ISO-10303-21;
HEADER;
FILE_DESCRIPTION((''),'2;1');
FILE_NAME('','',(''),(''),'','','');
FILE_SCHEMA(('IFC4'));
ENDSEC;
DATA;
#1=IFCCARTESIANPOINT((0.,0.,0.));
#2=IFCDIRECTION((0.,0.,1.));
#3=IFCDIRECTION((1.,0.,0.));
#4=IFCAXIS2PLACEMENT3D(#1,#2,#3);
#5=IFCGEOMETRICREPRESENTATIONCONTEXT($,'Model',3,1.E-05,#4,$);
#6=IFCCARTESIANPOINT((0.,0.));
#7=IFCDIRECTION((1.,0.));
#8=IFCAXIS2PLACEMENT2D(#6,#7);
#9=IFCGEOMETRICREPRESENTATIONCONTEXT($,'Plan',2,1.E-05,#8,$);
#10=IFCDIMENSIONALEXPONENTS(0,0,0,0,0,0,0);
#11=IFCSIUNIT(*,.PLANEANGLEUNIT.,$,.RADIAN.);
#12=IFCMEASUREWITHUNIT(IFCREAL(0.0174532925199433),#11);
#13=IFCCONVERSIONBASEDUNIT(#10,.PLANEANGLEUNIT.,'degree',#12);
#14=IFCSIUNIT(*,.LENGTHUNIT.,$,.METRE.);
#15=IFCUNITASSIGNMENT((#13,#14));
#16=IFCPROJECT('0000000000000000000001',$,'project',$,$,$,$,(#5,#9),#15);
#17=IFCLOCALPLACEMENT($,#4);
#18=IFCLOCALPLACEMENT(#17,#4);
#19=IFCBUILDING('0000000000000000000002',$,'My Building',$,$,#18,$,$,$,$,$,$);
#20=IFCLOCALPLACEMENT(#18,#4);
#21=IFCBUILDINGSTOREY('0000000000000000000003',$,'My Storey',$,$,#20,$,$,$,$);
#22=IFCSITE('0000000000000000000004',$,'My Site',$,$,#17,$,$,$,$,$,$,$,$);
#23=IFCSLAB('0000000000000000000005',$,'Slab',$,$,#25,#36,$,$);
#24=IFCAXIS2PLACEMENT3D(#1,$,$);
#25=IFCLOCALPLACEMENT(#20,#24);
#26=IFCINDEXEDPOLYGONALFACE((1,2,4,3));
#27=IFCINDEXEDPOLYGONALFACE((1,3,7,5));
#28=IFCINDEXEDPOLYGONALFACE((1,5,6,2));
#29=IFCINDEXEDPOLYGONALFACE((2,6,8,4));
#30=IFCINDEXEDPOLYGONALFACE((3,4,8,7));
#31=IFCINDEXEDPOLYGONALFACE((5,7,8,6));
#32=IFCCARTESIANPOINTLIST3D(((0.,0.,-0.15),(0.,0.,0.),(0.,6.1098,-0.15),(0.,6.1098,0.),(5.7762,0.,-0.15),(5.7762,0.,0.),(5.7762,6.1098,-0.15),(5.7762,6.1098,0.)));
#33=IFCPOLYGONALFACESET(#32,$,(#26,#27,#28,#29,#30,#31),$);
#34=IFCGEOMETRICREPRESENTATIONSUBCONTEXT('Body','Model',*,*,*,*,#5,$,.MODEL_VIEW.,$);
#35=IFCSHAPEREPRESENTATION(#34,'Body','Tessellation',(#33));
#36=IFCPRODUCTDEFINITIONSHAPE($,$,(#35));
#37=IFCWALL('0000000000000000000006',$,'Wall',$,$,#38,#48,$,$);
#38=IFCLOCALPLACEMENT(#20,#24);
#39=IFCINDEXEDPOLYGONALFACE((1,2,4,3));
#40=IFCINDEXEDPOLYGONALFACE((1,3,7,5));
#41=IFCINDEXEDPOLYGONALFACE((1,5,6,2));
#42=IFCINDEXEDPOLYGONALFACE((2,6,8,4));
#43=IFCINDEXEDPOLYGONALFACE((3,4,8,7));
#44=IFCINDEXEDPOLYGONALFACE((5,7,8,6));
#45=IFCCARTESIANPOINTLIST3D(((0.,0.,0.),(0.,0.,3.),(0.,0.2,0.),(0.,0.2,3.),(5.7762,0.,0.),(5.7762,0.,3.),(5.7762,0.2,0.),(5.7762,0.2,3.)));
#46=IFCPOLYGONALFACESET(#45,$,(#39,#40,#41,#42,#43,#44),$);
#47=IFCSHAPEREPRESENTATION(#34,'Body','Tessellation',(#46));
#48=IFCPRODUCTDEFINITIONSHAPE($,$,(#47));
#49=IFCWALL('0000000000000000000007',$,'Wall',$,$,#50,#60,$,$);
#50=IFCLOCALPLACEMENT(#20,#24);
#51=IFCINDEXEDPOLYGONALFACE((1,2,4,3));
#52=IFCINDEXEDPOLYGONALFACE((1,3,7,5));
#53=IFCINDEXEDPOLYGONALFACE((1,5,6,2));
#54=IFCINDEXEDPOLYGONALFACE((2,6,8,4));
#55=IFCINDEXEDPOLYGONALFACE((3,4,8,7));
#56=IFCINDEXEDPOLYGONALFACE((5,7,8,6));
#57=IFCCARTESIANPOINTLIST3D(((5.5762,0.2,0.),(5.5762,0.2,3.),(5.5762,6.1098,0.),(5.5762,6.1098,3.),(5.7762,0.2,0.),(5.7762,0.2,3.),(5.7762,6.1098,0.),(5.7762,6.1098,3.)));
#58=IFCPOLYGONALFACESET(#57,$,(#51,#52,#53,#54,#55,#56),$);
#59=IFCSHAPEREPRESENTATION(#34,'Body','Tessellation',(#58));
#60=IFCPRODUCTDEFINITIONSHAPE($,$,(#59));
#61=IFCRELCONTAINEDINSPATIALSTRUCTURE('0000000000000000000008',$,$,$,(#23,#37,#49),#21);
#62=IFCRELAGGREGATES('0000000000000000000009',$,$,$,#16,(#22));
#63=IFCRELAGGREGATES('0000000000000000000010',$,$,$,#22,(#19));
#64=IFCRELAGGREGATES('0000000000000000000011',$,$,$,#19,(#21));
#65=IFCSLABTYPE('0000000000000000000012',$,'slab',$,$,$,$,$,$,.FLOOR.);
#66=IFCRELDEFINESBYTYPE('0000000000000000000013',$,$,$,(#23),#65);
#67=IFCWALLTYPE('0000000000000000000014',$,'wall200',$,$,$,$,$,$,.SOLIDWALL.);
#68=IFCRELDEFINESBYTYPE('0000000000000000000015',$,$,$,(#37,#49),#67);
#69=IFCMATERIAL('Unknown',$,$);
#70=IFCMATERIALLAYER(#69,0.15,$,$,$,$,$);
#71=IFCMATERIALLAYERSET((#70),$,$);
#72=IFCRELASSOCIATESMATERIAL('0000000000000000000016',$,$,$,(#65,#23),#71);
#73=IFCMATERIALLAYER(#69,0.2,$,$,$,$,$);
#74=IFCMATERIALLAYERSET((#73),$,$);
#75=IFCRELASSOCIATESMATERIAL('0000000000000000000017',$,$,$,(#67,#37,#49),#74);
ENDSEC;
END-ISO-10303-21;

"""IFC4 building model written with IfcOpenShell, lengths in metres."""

from ifc_helpers import new_model, entity, si_unit, converted_unit, frame, origin_with_axes, origin_2d_with_axis, place, context, subcontext, project, spatial, line, indexed_curve, outline, extrude, material, layer, layer_set, layer_usage, type_object, element, save


model = new_model("IFC4")

# Units and contexts
model_context = context("Model", 3, precision=1e-05, world=origin_with_axes())
plan_context = context("Plan", 2, precision=1e-05, world=origin_2d_with_axis())
body_context = subcontext(model_context, "Body", "Model", "MODEL_VIEW")
ifc_project = project(units=[converted_unit("PLANEANGLEUNIT", "degree", entity("IfcReal", 0.0174532925199433), si_unit("PLANEANGLEUNIT", "RADIAN"), dimensions=[0, 0, 0, 0, 0, 0, 0]), si_unit("LENGTHUNIT", "METRE")], contexts=[model_context, plan_context])

# Site, building, storey
site_placement = place(None, origin_with_axes())
site = spatial("IfcSite", under=ifc_project, at=site_placement, Name="My Site")
building_placement = place(site_placement, origin_with_axes())
building = spatial("IfcBuilding", under=site, at=building_placement, Name="My Building")
storey_placement = place(building_placement, origin_with_axes())
storey = spatial("IfcBuildingStorey", under=building, at=storey_placement, Name="My Storey")

# Slab
ifc_material = material(Name="Unknown")
ifc_layer_1 = layer(ifc_material, 0.15)
ifc_layer_set_1 = layer_set([ifc_layer_1])
ifc_layer_usage_1 = layer_usage(ifc_layer_set_1, "AXIS3", "POSITIVE", 0.0)
slab_type = type_object("IfcSlabType", Name="slab", PredefinedType="FLOOR", material=ifc_layer_set_1)
slab_placement = place(storey_placement, frame((0.0, 0.0, -0.15), z_axis=(0.0, 0.0, 1.0), x_axis=(1.0, 0.0, 0.0)))
element("IfcSlab", 1, at=slab_placement, inside=storey, type_object=slab_type, material=ifc_layer_usage_1, Name="Slab", context=body_context, shape_type="SweptSolid", body=[
    extrude(outline(indexed_curve([(0.0, 0.0), (5.7762, 0.0), (5.7762, 6.1098), (0.0, 6.1098)], segments=[line(3, 2), line(2, 1), line(1, 4), line(4, 3)], self_intersect=False)), None, (0.0, 0.0, 1.0), 0.15),
])

# Walls
ifc_layer_2 = layer(ifc_material, 0.2)
ifc_layer_set_2 = layer_set([ifc_layer_2])
ifc_layer_usage_2 = layer_usage(ifc_layer_set_2, "AXIS2", "POSITIVE", 0.0)
wall_type = type_object("IfcWallType", Name="wall200", PredefinedType="SOLIDWALL", material=ifc_layer_set_2)
wall_1_placement = place(storey_placement, origin_with_axes())
element("IfcWall", 2, at=wall_1_placement, inside=storey, type_object=wall_type, material=ifc_layer_usage_2, Name="Wall", context=body_context, shape_type="SweptSolid", body=[
    extrude(outline(indexed_curve([(0.0, 0.0), (0.0, 0.2), (5.7762, 0.2), (5.7762, 0.0), (0.0, 0.0)], self_intersect=False)), origin_with_axes(), (0.0, 0.0, 1.0), 3.0),
])
ifc_layer_usage_3 = layer_usage(ifc_layer_set_2, "AXIS2", "POSITIVE", 0.0)
wall_2_placement = place(storey_placement, frame((5.7762, 0.2, 0.0), z_axis=(0.0, 0.0, 1.0), x_axis=(0.0, 1.0, 0.0)))
element("IfcWall", 3, at=wall_2_placement, inside=storey, type_object=wall_type, material=ifc_layer_usage_3, Name="Wall", context=body_context, shape_type="SweptSolid", body=[
    extrude(outline(indexed_curve([(0.0, 0.0), (0.0, 0.2), (5.9098, 0.2), (5.9098, 0.0), (0.0, 0.0)], self_intersect=False)), origin_with_axes(), (0.0, 0.0, 1.0), 3.0),
])

save(model, "model.ifc")
